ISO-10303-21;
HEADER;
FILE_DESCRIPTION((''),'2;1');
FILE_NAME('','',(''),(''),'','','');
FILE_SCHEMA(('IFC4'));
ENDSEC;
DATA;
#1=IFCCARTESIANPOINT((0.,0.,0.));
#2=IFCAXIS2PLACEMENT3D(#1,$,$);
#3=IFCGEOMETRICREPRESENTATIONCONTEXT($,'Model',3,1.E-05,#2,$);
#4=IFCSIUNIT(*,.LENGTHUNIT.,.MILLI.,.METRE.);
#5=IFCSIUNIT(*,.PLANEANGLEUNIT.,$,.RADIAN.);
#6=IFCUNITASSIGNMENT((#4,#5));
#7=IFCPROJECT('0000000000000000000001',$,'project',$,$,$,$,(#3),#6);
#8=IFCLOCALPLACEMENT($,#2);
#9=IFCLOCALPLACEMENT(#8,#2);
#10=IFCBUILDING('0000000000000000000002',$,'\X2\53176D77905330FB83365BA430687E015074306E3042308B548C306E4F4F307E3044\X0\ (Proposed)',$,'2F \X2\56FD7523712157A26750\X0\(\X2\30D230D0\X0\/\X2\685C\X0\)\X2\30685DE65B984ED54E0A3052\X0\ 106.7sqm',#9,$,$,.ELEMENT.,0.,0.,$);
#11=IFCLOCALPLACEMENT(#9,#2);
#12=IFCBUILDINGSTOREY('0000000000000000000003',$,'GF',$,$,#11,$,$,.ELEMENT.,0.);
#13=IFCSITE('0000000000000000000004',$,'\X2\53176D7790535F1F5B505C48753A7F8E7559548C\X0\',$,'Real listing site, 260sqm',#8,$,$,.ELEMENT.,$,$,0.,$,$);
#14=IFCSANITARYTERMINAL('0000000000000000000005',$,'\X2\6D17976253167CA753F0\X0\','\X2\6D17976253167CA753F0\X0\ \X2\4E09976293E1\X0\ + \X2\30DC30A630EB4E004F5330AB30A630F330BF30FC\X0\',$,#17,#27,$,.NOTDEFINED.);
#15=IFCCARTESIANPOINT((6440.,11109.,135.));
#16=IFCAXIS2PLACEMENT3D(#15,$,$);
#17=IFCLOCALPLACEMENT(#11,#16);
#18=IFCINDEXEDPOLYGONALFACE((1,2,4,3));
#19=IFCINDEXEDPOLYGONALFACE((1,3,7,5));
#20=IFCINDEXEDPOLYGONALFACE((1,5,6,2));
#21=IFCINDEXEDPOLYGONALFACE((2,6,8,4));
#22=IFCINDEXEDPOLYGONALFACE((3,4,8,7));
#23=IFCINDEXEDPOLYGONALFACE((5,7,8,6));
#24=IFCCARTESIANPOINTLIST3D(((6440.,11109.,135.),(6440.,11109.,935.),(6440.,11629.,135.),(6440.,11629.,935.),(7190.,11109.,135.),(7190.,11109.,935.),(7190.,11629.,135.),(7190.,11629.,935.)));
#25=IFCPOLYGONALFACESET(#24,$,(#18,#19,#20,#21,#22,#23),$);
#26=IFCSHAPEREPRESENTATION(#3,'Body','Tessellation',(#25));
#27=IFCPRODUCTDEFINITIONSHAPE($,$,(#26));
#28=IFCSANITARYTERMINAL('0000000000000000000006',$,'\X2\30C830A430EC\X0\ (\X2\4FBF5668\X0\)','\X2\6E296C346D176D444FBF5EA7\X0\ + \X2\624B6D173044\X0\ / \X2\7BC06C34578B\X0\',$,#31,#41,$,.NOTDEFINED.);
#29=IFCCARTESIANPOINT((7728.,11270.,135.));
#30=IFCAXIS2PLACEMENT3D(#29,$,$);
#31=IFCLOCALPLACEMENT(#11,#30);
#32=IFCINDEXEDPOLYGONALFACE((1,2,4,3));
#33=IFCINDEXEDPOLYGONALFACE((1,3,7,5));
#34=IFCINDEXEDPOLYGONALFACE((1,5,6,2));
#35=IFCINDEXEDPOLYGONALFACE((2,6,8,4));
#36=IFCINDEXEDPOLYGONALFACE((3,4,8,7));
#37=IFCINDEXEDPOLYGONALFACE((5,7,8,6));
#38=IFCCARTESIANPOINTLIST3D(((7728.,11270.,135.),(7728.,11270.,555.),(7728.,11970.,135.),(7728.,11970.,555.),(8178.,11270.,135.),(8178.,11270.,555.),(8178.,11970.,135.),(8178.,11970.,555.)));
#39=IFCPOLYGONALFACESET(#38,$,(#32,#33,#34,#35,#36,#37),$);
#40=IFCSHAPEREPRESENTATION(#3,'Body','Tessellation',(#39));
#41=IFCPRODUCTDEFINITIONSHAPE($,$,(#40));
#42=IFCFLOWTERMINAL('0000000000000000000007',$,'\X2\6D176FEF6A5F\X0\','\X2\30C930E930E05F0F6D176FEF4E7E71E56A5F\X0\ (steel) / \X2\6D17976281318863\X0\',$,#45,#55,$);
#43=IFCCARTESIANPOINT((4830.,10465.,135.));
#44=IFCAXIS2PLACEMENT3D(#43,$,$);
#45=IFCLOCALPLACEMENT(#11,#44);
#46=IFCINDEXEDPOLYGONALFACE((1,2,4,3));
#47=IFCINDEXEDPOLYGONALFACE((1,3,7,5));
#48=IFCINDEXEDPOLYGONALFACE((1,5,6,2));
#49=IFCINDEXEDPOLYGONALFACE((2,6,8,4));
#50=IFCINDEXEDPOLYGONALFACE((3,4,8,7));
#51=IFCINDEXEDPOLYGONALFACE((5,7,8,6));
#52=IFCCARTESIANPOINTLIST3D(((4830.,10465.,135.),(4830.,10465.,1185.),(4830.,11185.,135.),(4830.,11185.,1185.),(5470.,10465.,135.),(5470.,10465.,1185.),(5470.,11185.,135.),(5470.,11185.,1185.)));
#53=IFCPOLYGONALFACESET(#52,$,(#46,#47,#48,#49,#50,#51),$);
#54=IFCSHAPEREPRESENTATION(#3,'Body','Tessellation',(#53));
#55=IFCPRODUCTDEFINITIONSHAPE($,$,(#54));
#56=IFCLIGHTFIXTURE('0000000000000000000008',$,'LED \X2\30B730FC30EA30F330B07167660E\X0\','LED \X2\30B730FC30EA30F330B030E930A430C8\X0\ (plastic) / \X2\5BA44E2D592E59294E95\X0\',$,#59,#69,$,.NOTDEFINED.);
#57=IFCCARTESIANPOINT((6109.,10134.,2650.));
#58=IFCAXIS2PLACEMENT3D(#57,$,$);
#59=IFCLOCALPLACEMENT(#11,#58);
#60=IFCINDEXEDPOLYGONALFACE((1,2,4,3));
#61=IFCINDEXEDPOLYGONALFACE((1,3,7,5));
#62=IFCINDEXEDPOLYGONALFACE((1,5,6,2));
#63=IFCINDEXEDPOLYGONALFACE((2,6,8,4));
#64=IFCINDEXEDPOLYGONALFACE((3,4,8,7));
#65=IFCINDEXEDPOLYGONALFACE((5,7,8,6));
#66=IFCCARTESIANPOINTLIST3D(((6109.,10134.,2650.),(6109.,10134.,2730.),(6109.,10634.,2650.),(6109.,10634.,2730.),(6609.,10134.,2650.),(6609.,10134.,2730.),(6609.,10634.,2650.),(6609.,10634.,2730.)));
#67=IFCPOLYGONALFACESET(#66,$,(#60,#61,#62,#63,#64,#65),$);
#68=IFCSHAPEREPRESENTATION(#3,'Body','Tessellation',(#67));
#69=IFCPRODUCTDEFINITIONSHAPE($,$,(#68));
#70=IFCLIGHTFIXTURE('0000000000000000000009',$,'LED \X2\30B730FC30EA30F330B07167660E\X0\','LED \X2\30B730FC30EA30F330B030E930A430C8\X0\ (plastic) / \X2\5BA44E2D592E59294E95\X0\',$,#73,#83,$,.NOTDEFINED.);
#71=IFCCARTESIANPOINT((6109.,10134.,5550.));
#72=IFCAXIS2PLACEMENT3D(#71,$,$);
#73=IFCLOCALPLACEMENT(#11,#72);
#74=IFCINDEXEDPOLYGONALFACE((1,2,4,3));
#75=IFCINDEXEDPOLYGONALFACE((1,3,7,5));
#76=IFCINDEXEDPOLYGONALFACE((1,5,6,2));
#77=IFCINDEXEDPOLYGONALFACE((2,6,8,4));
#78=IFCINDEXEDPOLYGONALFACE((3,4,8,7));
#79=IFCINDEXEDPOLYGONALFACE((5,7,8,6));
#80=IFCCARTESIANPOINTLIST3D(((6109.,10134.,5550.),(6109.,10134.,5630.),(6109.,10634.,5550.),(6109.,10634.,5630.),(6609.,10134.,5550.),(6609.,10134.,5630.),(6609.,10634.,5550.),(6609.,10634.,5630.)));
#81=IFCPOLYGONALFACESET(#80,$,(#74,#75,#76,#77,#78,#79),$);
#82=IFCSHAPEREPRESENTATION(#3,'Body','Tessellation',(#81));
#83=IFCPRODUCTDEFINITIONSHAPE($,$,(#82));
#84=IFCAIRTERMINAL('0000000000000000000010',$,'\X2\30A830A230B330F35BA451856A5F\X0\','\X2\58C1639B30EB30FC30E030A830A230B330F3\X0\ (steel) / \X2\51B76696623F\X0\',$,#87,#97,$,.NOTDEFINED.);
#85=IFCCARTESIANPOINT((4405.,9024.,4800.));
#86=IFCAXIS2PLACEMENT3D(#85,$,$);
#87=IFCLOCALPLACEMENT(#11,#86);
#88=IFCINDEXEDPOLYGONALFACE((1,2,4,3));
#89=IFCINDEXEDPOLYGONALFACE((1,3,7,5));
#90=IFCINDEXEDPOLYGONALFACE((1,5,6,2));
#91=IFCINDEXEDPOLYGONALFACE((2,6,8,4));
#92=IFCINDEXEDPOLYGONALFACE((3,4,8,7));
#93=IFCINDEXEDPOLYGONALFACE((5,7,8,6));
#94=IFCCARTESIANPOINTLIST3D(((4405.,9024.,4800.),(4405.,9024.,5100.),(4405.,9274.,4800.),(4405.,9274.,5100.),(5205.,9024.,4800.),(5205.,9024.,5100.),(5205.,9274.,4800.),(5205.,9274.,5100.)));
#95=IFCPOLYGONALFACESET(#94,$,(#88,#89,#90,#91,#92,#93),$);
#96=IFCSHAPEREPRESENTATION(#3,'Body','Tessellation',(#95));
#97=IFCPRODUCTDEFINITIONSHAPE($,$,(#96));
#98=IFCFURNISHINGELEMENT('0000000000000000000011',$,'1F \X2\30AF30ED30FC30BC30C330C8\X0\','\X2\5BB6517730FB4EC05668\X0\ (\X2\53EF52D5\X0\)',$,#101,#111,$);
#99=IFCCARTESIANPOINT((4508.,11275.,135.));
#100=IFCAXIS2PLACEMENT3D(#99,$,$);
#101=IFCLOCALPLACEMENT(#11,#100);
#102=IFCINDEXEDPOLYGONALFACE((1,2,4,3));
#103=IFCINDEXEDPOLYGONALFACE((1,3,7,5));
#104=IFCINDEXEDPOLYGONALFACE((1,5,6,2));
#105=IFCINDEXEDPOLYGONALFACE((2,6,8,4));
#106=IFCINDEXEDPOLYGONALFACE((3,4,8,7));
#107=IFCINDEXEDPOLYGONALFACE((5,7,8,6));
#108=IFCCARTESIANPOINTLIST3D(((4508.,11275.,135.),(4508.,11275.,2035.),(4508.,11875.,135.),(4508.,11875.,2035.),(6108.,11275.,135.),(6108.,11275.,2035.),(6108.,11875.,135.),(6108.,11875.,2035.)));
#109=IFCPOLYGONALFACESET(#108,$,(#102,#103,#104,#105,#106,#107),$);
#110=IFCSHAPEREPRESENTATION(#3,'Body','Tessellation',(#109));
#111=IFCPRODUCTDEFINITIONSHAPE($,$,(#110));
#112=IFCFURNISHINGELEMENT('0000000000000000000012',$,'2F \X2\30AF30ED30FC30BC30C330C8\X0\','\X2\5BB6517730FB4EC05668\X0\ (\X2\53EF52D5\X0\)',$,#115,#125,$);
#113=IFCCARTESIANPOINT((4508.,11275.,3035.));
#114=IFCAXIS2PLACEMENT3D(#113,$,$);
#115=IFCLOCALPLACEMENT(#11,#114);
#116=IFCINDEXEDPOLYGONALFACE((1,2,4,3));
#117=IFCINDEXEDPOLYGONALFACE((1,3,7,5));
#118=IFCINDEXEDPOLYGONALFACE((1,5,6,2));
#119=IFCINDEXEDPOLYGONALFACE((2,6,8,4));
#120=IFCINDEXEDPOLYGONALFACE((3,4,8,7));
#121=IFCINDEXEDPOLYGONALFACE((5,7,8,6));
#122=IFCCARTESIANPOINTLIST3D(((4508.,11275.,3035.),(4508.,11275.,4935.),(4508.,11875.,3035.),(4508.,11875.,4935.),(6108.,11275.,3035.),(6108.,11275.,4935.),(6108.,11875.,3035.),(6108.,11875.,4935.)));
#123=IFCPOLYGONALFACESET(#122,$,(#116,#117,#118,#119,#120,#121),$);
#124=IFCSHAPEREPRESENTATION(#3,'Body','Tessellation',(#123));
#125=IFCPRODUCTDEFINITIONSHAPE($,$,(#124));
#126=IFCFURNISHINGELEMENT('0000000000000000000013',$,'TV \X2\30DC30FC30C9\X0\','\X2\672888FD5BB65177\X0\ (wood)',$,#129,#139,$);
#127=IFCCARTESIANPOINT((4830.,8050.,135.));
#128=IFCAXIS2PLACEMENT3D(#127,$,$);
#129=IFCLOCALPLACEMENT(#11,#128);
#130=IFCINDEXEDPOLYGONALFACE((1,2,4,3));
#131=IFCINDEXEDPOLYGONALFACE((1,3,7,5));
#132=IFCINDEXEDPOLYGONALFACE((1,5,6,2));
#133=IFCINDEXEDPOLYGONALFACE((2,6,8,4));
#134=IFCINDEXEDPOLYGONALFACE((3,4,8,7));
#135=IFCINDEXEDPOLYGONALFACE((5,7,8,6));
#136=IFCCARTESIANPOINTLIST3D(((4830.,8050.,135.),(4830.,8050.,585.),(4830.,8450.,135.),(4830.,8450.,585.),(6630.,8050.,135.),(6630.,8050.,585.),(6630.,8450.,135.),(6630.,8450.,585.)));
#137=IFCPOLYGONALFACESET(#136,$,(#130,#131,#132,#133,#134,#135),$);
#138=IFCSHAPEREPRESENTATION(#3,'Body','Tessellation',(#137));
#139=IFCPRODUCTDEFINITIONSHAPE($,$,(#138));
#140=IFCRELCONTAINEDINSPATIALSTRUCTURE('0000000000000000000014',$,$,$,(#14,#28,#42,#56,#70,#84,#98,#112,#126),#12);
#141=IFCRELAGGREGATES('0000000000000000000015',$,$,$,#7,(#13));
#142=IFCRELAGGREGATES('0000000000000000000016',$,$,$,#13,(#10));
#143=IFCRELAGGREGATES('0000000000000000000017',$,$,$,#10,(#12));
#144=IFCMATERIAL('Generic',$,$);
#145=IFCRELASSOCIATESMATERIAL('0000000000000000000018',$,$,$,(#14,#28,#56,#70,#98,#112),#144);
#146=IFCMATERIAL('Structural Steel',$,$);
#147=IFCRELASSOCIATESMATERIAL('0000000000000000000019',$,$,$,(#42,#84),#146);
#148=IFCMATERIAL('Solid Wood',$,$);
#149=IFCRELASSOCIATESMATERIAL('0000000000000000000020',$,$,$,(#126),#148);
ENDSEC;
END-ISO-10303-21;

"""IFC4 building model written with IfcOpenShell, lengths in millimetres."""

from ifc_helpers import new_model, si_unit, frame, frame_2d, origin, place, context, project, spatial, rectangle, extrude, material, element, save


model = new_model("IFC4")

# Units and contexts
model_context = context("Model", 3, precision=1e-05, world=origin())
ifc_project = project(units=[si_unit("LENGTHUNIT", "METRE", prefix="MILLI"), si_unit("PLANEANGLEUNIT", "RADIAN")], contexts=[model_context])

# Site, building, storey
site_placement = place(None, origin())
site = spatial("IfcSite", under=ifc_project, at=site_placement, Name="北海道弟子屈町美留和", ObjectType="Real listing site, 260sqm", CompositionType="ELEMENT", RefElevation=0.0)
building_placement = place(site_placement, origin())
building = spatial("IfcBuilding", under=site, at=building_placement, Name="北海道・茶室と縁側のある和の住まい (Proposed)", ObjectType="2F 国産無垢材(ヒバ/桜)と左官仕上げ 106.7sqm", CompositionType="ELEMENT", ElevationOfRefHeight=0.0, ElevationOfTerrain=0.0)
storey_placement = place(building_placement, origin())
storey = spatial("IfcBuildingStorey", under=building, at=storey_placement, Name="GF", CompositionType="ELEMENT", Elevation=0.0)

# Shared definitions
ifc_material_1 = material(Name="Solid Wood")

# Sanitary terminals
ifc_material_2 = material(Name="Generic")
sanitary_terminal_1_placement = place(storey_placement, frame((6440.0, 11109.0, 135.0)))
element("IfcSanitaryTerminal", 1, at=sanitary_terminal_1_placement, inside=storey, material=ifc_material_2, Name="洗面化粧台", Description="洗面化粧台 三面鏡 + ボウル一体カウンター", PredefinedType="NOTDEFINED", context=model_context, shape_type="SweptSolid", body=[
    extrude(rectangle(XDim=750.0, YDim=520.0, at=frame_2d((375.0, 260.0))), frame((6440.0, 11109.0, 135.0)), (0.0, 0.0, 1.0), 800.0),
])
sanitary_terminal_2_placement = place(storey_placement, frame((7728.0, 11270.0, 135.0)))
element("IfcSanitaryTerminal", 2, at=sanitary_terminal_2_placement, inside=storey, material=ifc_material_2, Name="トイレ (便器)", Description="温水洗浄便座 + 手洗い / 節水型", PredefinedType="NOTDEFINED", context=model_context, shape_type="SweptSolid", body=[
    extrude(rectangle(XDim=450.0, YDim=700.0, at=frame_2d((225.0, 350.0))), frame((7728.0, 11270.0, 135.0)), (0.0, 0.0, 1.0), 420.0),
])

# Flow terminal
ifc_material_3 = material(Name="Structural Steel")
flow_terminal_placement = place(storey_placement, frame((4830.0, 10465.0, 135.0)))
element("IfcFlowTerminal", 3, at=flow_terminal_placement, inside=storey, material=ifc_material_3, Name="洗濯機", Description="ドラム式洗濯乾燥機 (steel) / 洗面脱衣", context=model_context, shape_type="SweptSolid", body=[
    extrude(rectangle(XDim=640.0, YDim=720.0, at=frame_2d((320.0, 360.0))), frame((4830.0, 10465.0, 135.0)), (0.0, 0.0, 1.0), 1050.0),
])

# Light fixtures
light_fixture_1_placement = place(storey_placement, frame((6109.0, 10134.0, 2650.0)))
element("IfcLightFixture", 4, at=light_fixture_1_placement, inside=storey, material=ifc_material_2, Name="LED シーリング照明", Description="LED シーリングライト (plastic) / 室中央天井", PredefinedType="NOTDEFINED", context=model_context, shape_type="SweptSolid", body=[
    extrude(rectangle(XDim=500.0, YDim=500.0, at=frame_2d((250.0, 250.0))), frame((6109.0, 10134.0, 2650.0)), (0.0, 0.0, 1.0), 80.0),
])
light_fixture_2_placement = place(storey_placement, frame((6109.0, 10134.0, 5550.0)))
element("IfcLightFixture", 5, at=light_fixture_2_placement, inside=storey, material=ifc_material_2, Name="LED シーリング照明", Description="LED シーリングライト (plastic) / 室中央天井", PredefinedType="NOTDEFINED", context=model_context, shape_type="SweptSolid", body=[
    extrude(rectangle(XDim=500.0, YDim=500.0, at=frame_2d((250.0, 250.0))), frame((6109.0, 10134.0, 5550.0)), (0.0, 0.0, 1.0), 80.0),
])

# Air terminal
air_terminal_placement = place(storey_placement, frame((4405.0, 9024.0, 4800.0)))
element("IfcAirTerminal", 6, at=air_terminal_placement, inside=storey, material=ifc_material_3, Name="エアコン室内機", Description="壁掛ルームエアコン (steel) / 冷暖房", PredefinedType="NOTDEFINED", context=model_context, shape_type="SweptSolid", body=[
    extrude(rectangle(XDim=800.0, YDim=250.0, at=frame_2d((400.0, 125.0))), frame((4405.0, 9024.0, 4800.0)), (0.0, 0.0, 1.0), 300.0),
])

# Furnishing elements
furnishing_1_placement = place(storey_placement, frame((4508.0, 11275.0, 135.0)))
element("IfcFurnishingElement", 7, at=furnishing_1_placement, inside=storey, material=ifc_material_2, Name="1F クローゼット", Description="家具・什器 (可動)", context=model_context, shape_type="SweptSolid", body=[
    extrude(rectangle(XDim=1600.0, YDim=600.0, at=frame_2d((800.0, 300.0))), frame((4508.0, 11275.0, 135.0)), (0.0, 0.0, 1.0), 1900.0),
])
furnishing_2_placement = place(storey_placement, frame((4508.0, 11275.0, 3035.0)))
element("IfcFurnishingElement", 8, at=furnishing_2_placement, inside=storey, material=ifc_material_2, Name="2F クローゼット", Description="家具・什器 (可動)", context=model_context, shape_type="SweptSolid", body=[
    extrude(rectangle(XDim=1600.0, YDim=600.0, at=frame_2d((800.0, 300.0))), frame((4508.0, 11275.0, 3035.0)), (0.0, 0.0, 1.0), 1900.0),
])
furnishing_3_placement = place(storey_placement, frame((4830.0, 8050.0, 135.0)))
element("IfcFurnishingElement", 9, at=furnishing_3_placement, inside=storey, material=ifc_material_1, Name="TV ボード", Description="木製家具 (wood)", context=model_context, shape_type="SweptSolid", body=[
    extrude(rectangle(XDim=1800.0, YDim=400.0, at=frame_2d((900.0, 200.0))), frame((4830.0, 8050.0, 135.0)), (0.0, 0.0, 1.0), 450.0),
])

save(model, "model.ifc")
